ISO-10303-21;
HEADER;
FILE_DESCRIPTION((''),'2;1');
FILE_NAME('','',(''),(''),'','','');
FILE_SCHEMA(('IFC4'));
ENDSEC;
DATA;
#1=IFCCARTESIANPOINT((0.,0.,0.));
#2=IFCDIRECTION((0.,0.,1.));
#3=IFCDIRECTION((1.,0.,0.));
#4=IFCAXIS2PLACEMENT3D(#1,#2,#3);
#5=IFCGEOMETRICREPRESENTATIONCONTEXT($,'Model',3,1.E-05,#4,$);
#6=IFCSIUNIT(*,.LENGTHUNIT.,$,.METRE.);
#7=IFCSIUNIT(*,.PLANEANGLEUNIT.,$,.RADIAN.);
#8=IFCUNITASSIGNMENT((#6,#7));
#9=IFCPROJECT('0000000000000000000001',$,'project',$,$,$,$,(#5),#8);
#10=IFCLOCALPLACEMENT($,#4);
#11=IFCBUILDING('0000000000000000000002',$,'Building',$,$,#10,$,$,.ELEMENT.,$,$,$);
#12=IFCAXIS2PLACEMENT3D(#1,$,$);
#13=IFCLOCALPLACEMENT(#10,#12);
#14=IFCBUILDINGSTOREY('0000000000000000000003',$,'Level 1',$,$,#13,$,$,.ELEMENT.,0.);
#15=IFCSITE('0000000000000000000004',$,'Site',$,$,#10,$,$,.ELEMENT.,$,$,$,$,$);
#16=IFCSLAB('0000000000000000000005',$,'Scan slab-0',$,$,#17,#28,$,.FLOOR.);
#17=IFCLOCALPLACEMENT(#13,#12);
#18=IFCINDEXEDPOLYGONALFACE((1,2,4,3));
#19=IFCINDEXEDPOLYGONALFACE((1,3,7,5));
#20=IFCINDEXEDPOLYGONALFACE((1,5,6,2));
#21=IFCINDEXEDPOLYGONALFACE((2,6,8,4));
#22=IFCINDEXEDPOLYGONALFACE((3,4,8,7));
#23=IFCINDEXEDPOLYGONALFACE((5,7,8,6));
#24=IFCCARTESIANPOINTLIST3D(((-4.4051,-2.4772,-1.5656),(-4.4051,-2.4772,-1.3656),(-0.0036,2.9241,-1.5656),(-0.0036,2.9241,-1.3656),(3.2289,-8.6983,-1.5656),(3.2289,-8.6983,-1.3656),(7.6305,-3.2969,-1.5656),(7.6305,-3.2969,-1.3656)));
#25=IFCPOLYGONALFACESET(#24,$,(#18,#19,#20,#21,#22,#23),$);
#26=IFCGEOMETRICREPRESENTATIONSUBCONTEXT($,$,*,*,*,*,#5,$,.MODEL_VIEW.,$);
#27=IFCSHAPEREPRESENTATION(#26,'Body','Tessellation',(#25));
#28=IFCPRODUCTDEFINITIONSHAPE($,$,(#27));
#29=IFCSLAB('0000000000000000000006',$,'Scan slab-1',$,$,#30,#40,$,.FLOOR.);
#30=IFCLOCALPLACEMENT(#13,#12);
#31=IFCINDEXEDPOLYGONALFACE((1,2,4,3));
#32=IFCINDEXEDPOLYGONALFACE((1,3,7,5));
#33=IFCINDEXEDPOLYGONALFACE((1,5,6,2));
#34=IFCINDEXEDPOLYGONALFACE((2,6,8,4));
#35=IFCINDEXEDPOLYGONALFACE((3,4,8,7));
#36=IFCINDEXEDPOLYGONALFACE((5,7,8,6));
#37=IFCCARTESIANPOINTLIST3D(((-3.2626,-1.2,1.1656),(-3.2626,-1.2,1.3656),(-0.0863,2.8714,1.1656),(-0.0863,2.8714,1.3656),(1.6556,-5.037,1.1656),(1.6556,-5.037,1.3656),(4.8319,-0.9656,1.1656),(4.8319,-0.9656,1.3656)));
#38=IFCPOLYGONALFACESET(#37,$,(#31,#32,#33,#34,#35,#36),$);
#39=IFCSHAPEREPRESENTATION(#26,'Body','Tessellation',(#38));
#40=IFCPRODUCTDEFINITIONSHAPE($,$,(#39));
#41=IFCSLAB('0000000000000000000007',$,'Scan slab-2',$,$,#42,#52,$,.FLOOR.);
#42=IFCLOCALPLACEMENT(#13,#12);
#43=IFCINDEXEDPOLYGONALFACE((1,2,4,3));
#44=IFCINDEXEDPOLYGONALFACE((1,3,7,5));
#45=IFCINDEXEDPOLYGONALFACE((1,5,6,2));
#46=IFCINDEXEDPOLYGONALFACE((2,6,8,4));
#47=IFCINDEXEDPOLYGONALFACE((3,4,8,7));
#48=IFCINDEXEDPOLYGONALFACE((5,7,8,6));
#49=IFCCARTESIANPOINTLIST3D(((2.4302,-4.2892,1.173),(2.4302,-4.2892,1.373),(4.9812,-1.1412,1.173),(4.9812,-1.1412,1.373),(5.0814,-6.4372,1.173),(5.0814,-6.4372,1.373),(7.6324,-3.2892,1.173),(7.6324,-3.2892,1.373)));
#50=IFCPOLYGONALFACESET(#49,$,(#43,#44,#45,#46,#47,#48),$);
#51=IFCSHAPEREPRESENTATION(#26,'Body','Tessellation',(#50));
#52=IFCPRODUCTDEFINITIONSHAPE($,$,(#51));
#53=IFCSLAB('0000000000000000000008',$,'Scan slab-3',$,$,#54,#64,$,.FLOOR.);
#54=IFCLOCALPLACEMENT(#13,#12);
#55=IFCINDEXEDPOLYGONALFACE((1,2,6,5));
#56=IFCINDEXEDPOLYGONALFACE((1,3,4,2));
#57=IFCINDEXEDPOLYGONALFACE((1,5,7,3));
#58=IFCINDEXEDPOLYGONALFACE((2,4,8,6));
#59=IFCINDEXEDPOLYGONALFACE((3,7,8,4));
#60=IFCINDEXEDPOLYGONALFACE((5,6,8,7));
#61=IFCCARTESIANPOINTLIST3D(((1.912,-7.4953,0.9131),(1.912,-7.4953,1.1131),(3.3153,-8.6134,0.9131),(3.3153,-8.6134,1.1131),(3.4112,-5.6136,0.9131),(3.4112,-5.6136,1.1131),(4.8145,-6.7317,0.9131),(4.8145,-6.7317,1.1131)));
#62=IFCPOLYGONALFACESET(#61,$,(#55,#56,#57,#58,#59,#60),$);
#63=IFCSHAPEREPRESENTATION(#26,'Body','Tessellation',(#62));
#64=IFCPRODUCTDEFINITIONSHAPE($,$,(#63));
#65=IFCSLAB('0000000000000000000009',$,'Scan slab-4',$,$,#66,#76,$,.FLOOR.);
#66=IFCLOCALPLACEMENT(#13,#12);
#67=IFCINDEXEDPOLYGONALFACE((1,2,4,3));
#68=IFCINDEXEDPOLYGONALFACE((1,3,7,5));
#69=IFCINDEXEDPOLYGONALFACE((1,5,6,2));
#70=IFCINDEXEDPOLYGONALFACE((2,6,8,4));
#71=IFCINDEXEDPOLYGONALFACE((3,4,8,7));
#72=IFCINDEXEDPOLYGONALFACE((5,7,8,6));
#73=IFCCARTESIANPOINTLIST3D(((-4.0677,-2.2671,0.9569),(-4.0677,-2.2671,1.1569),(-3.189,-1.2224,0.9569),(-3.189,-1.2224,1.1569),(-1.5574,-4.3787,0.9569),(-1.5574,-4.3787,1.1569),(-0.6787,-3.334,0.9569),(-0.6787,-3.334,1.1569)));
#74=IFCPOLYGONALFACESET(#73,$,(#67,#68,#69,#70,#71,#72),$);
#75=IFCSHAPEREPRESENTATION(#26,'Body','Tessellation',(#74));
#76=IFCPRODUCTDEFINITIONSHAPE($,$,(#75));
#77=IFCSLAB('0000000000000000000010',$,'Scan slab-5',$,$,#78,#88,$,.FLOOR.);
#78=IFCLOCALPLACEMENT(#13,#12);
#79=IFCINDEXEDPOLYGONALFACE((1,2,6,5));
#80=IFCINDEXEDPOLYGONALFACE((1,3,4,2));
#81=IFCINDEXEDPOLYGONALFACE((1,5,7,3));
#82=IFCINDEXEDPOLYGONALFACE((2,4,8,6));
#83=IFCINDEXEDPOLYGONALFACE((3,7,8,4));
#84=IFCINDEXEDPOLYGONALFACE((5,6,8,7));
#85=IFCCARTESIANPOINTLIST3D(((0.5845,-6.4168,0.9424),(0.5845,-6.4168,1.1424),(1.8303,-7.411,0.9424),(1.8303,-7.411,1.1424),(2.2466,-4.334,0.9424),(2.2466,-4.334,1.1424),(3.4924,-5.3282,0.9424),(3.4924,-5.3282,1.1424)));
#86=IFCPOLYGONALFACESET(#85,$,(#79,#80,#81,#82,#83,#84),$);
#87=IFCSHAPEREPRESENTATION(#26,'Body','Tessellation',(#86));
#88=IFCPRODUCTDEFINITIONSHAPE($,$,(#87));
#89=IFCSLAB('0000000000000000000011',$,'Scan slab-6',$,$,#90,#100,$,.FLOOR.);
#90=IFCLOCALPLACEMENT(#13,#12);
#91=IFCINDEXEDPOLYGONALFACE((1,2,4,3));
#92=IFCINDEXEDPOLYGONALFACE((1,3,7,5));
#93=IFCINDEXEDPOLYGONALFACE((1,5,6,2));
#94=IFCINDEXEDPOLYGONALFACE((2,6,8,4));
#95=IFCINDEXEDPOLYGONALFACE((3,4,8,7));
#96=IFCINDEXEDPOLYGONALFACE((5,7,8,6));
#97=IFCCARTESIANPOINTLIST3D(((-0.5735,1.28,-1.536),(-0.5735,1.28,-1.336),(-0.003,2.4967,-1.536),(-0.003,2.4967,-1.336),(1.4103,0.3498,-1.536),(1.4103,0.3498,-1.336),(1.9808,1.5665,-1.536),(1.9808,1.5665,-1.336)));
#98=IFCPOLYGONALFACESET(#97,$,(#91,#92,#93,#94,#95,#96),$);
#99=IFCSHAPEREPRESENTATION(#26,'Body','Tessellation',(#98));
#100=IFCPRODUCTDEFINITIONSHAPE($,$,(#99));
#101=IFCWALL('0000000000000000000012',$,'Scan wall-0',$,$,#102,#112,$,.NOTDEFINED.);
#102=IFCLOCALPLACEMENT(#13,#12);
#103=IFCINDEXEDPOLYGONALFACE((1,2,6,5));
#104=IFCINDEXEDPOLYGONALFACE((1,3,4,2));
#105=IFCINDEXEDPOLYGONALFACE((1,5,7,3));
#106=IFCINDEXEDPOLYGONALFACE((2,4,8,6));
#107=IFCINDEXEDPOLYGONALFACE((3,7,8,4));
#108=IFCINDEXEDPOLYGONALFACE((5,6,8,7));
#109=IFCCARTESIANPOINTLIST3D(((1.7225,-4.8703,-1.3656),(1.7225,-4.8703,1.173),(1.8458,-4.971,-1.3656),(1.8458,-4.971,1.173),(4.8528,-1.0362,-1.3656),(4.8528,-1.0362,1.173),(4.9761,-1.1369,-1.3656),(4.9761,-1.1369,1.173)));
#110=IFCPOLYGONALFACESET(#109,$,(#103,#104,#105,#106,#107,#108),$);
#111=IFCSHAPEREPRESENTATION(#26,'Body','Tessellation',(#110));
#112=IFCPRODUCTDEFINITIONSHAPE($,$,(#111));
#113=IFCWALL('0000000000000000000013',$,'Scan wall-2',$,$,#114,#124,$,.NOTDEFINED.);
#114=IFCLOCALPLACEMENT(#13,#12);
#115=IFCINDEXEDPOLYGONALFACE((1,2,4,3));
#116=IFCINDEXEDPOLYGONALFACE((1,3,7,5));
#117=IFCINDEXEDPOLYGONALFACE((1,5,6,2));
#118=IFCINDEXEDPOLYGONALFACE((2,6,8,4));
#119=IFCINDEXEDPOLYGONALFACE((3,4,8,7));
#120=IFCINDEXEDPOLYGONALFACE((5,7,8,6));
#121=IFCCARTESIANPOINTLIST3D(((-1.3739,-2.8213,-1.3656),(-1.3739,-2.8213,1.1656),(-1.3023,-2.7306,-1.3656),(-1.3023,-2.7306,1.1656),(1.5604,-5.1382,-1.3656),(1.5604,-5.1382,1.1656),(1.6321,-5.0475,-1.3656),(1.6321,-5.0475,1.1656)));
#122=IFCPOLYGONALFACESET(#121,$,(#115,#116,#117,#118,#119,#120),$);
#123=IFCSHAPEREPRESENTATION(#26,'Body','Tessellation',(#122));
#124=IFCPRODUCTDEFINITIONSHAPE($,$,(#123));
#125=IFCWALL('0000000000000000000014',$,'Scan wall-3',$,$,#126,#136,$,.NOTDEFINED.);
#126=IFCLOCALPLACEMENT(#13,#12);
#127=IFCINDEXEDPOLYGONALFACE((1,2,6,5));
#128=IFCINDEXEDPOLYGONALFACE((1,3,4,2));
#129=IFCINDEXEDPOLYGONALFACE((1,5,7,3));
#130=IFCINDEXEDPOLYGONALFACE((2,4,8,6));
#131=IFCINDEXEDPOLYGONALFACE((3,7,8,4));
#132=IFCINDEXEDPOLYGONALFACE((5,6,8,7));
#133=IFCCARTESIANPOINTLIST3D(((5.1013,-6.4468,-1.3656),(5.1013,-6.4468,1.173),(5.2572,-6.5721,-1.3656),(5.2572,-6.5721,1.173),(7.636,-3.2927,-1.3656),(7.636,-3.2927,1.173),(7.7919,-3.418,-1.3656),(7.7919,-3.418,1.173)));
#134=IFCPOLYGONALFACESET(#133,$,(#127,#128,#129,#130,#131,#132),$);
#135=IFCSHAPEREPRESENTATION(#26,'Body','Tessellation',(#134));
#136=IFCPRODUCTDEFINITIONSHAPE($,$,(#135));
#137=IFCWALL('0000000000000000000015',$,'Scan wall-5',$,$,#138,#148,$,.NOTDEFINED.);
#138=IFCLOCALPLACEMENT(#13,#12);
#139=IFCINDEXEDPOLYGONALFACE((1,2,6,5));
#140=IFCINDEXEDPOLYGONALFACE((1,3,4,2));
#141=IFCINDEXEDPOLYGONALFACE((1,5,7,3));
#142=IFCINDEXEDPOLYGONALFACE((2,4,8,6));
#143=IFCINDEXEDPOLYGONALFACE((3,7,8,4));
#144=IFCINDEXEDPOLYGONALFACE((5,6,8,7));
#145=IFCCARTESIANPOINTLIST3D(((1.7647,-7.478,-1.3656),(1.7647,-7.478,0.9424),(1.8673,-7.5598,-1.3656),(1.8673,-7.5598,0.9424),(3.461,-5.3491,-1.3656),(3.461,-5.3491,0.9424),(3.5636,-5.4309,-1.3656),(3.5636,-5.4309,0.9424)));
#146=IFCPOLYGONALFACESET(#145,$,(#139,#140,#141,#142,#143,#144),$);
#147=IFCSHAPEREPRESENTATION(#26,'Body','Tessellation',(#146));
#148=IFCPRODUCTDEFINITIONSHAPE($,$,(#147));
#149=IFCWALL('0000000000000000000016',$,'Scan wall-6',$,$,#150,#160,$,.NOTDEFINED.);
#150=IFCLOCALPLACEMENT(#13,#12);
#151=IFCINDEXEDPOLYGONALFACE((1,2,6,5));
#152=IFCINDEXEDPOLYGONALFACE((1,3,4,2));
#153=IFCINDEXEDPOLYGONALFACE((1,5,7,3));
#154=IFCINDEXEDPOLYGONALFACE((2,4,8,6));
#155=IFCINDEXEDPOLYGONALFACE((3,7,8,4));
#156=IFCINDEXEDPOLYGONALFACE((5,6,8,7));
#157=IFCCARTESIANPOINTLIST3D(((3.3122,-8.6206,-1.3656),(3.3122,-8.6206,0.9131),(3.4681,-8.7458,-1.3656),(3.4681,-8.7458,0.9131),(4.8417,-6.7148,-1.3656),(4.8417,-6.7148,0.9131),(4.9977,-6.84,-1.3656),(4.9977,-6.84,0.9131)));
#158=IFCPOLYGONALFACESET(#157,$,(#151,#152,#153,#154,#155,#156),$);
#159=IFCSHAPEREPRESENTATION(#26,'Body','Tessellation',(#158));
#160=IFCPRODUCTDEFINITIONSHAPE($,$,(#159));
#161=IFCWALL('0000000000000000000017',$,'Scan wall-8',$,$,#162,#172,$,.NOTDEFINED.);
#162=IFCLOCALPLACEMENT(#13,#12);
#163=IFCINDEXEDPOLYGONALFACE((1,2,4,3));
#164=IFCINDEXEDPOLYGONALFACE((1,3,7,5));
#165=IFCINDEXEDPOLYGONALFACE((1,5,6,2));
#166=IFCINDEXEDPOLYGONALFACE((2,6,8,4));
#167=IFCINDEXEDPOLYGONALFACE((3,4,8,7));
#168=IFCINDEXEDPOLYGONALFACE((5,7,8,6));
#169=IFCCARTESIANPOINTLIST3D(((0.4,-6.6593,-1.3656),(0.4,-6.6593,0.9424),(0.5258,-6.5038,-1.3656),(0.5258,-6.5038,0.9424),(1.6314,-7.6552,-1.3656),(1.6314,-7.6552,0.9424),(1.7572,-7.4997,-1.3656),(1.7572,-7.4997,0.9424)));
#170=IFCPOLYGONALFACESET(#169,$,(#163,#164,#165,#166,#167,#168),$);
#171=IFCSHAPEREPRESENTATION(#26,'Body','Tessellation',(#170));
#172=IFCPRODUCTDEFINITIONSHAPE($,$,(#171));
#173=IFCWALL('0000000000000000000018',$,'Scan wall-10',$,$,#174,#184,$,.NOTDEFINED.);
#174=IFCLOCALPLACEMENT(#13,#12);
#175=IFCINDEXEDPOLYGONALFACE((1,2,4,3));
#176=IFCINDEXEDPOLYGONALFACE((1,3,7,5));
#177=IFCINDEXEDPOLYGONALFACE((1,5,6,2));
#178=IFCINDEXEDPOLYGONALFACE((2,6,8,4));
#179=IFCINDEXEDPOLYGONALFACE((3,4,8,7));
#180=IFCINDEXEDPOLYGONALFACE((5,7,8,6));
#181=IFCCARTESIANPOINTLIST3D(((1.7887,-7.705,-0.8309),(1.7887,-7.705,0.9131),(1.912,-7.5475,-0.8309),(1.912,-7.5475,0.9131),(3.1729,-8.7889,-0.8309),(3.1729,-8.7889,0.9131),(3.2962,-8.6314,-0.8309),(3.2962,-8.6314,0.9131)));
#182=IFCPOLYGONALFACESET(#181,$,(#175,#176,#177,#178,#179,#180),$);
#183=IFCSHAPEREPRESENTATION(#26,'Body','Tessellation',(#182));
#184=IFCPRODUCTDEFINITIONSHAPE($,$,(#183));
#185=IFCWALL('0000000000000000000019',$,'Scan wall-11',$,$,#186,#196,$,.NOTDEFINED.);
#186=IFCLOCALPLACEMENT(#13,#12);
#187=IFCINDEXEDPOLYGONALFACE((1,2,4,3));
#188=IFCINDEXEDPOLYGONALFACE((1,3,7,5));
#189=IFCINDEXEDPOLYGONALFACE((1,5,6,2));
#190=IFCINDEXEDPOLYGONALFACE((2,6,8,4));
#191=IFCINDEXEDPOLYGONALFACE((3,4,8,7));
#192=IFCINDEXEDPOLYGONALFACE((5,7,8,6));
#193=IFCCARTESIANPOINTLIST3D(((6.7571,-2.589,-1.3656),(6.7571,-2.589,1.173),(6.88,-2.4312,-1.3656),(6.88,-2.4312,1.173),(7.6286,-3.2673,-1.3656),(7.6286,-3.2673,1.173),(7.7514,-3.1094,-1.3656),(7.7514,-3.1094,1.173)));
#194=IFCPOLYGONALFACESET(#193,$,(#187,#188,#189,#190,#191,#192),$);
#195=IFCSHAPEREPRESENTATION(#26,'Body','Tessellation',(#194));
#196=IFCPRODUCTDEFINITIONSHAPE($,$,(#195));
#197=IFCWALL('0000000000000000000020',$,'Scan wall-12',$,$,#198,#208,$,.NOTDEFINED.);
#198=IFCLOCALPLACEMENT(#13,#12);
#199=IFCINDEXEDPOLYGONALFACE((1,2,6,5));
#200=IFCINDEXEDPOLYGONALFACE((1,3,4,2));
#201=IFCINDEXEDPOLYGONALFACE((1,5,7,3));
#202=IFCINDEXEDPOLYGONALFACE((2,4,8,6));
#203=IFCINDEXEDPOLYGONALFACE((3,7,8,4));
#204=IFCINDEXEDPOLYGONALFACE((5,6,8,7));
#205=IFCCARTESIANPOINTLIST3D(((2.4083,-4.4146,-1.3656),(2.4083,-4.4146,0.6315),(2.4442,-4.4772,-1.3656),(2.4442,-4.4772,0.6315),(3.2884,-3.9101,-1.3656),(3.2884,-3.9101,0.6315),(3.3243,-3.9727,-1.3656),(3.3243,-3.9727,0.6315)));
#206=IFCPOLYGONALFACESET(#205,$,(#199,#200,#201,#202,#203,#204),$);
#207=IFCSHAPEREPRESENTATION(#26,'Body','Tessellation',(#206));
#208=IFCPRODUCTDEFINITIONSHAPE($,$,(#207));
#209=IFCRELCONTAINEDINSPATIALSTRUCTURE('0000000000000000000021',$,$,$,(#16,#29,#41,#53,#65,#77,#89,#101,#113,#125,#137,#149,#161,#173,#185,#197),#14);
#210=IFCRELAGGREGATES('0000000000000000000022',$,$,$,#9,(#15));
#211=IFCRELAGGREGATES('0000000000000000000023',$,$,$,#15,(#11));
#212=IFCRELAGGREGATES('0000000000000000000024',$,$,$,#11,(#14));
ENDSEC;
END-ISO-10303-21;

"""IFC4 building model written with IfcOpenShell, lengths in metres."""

from ifc_helpers import new_model, si_unit, frame, frame_2d, origin, origin_with_axes, place, context, subcontext, project, spatial, polyline, rectangle, outline, extrude, element, save


model = new_model("IFC4")

# Units and contexts
model_context = context("Model", 3, precision=1e-05, world=origin_with_axes())
sub_context = subcontext(model_context, None, None, "MODEL_VIEW")
ifc_project = project(units=[si_unit("LENGTHUNIT", "METRE"), si_unit("PLANEANGLEUNIT", "RADIAN")], contexts=[model_context])

# Site, building, storey
placement = place(None, origin_with_axes())
site = spatial("IfcSite", under=ifc_project, at=placement, Name="Site", CompositionType="ELEMENT")
building = spatial("IfcBuilding", under=site, at=placement, Name="Building", CompositionType="ELEMENT")
storey_placement = place(placement, origin())
storey = spatial("IfcBuildingStorey", under=building, at=storey_placement, Name="Level 1", CompositionType="ELEMENT", Elevation=0.0)

# Slabs
slab_1_placement = place(storey_placement, frame((0.0, 0.0, -1.5656)))
element("IfcSlab", 1, at=slab_1_placement, inside=storey, Name="Scan slab-0", PredefinedType="FLOOR", context=sub_context, shape_type="SweptSolid", body=[
    extrude(outline(polyline([(-4.4051, -2.4772), (3.2289, -8.6983), (7.6305, -3.2969), (-0.0036, 2.9241), (-4.4051, -2.4772)])), origin(), (0.0, 0.0, 1.0), 0.2),
])
slab_2_placement = place(storey_placement, frame((0.0, 0.0, 1.1656)))
element("IfcSlab", 2, at=slab_2_placement, inside=storey, Name="Scan slab-1", PredefinedType="FLOOR", context=sub_context, shape_type="SweptSolid", body=[
    extrude(outline(polyline([(-3.2626, -1.2), (1.6556, -5.037), (4.8319, -0.9656), (-0.0863, 2.8714), (-3.2626, -1.2)])), origin(), (0.0, 0.0, 1.0), 0.2),
])
slab_3_placement = place(storey_placement, frame((0.0, 0.0, 1.173)))
element("IfcSlab", 3, at=slab_3_placement, inside=storey, Name="Scan slab-2", PredefinedType="FLOOR", context=sub_context, shape_type="SweptSolid", body=[
    extrude(outline(polyline([(4.9812, -1.1412), (2.4302, -4.2892), (5.0814, -6.4372), (7.6324, -3.2892), (4.9812, -1.1412)])), origin(), (0.0, 0.0, 1.0), 0.2),
])
slab_4_placement = place(storey_placement, frame((0.0, 0.0, 0.9131)))
element("IfcSlab", 4, at=slab_4_placement, inside=storey, Name="Scan slab-3", PredefinedType="FLOOR", context=sub_context, shape_type="SweptSolid", body=[
    extrude(outline(polyline([(1.912, -7.4953), (3.3153, -8.6134), (4.8145, -6.7317), (3.4112, -5.6136), (1.912, -7.4953)])), origin(), (0.0, 0.0, 1.0), 0.2),
])
slab_5_placement = place(storey_placement, frame((0.0, 0.0, 0.9569)))
element("IfcSlab", 5, at=slab_5_placement, inside=storey, Name="Scan slab-4", PredefinedType="FLOOR", context=sub_context, shape_type="SweptSolid", body=[
    extrude(outline(polyline([(-4.0677, -2.2671), (-1.5574, -4.3787), (-0.6787, -3.334), (-3.189, -1.2224), (-4.0677, -2.2671)])), origin(), (0.0, 0.0, 1.0), 0.2),
])
slab_6_placement = place(storey_placement, frame((0.0, 0.0, 0.9424)))
element("IfcSlab", 6, at=slab_6_placement, inside=storey, Name="Scan slab-5", PredefinedType="FLOOR", context=sub_context, shape_type="SweptSolid", body=[
    extrude(outline(polyline([(2.2466, -4.334), (0.5845, -6.4168), (1.8303, -7.411), (3.4924, -5.3282), (2.2466, -4.334)])), origin(), (0.0, 0.0, 1.0), 0.2),
])
slab_7_placement = place(storey_placement, frame((0.0, 0.0, -1.536)))
element("IfcSlab", 7, at=slab_7_placement, inside=storey, Name="Scan slab-6", PredefinedType="FLOOR", context=sub_context, shape_type="SweptSolid", body=[
    extrude(outline(polyline([(-0.5735, 1.28), (1.4103, 0.3498), (1.9808, 1.5665), (-0.003, 2.4967), (-0.5735, 1.28)])), origin(), (0.0, 0.0, 1.0), 0.2),
])

# Walls
wall_1_placement = place(storey_placement, frame((1.7841, -4.9207, -1.3656), z_axis=(0.0, 0.0, 1.0), x_axis=(0.632426, 0.774621, 0.0)))
element("IfcWall", 8, at=wall_1_placement, inside=storey, Name="Scan wall-0", PredefinedType="NOTDEFINED", context=sub_context, shape_type="SweptSolid", body=[
    extrude(rectangle(XDim=4.9496, YDim=0.1592, at=frame_2d((2.4748, 0.0))), origin(), (0.0, 0.0, 1.0), 2.5386),
])
wall_2_placement = place(storey_placement, frame((1.5962, -5.0929, -1.3656), z_axis=(0.0, 0.0, 1.0), x_axis=(-0.784842, 0.619696, 0.0)))
element("IfcWall", 9, at=wall_2_placement, inside=storey, Name="Scan wall-2", PredefinedType="NOTDEFINED", context=sub_context, shape_type="SweptSolid", body=[
    extrude(rectangle(XDim=3.7388, YDim=0.1156, at=frame_2d((1.8694, 0.0))), origin(), (0.0, 0.0, 1.0), 2.5311),
])
wall_3_placement = place(storey_placement, frame((5.1792, -6.5095, -1.3656), z_axis=(0.0, 0.0, 1.0), x_axis=(0.626416, 0.779489, 0.0)))
element("IfcWall", 10, at=wall_3_placement, inside=storey, Name="Scan wall-3", PredefinedType="NOTDEFINED", context=sub_context, shape_type="SweptSolid", body=[
    extrude(rectangle(XDim=4.0464, YDim=0.2, at=frame_2d((2.0232, 0.0))), origin(), (0.0, 0.0, 1.0), 2.5386),
])
wall_4_placement = place(storey_placement, frame((1.816, -7.5189, -1.3656), z_axis=(0.0, 0.0, 1.0), x_axis=(0.623176, 0.782082, 0.0)))
element("IfcWall", 11, at=wall_4_placement, inside=storey, Name="Scan wall-5", PredefinedType="NOTDEFINED", context=sub_context, shape_type="SweptSolid", body=[
    extrude(rectangle(XDim=2.7221, YDim=0.1312, at=frame_2d((1.361, 0.0))), origin(), (0.0, 0.0, 1.0), 2.3079),
])
wall_5_placement = place(storey_placement, frame((3.3901, -8.6832, -1.3656), z_axis=(0.0, 0.0, 1.0), x_axis=(0.625935, 0.779875, 0.0)))
element("IfcWall", 12, at=wall_5_placement, inside=storey, Name="Scan wall-6", PredefinedType="NOTDEFINED", context=sub_context, shape_type="SweptSolid", body=[
    extrude(rectangle(XDim=2.4437, YDim=0.2, at=frame_2d((1.2218, 0.0))), origin(), (0.0, 0.0, 1.0), 2.2786),
])
wall_6_placement = place(storey_placement, frame((1.6943, -7.5775, -1.3656), z_axis=(0.0, 0.0, 1.0), x_axis=(-0.77751, 0.62887, 0.0)))
element("IfcWall", 13, at=wall_6_placement, inside=storey, Name="Scan wall-8", PredefinedType="NOTDEFINED", context=sub_context, shape_type="SweptSolid", body=[
    extrude(rectangle(XDim=1.5838, YDim=0.2, at=frame_2d((0.7919, 0.0))), origin(), (0.0, 0.0, 1.0), 2.3079),
])
wall_7_placement = place(storey_placement, frame((3.2345, -8.7101, -0.8309), z_axis=(0.0, 0.0, 1.0), x_axis=(-0.787339, 0.616521, 0.0)))
element("IfcWall", 14, at=wall_7_placement, inside=storey, Name="Scan wall-10", PredefinedType="NOTDEFINED", context=sub_context, shape_type="SweptSolid", body=[
    extrude(rectangle(XDim=1.7581, YDim=0.2, at=frame_2d((0.879, 0.0))), origin(), (0.0, 0.0, 1.0), 1.7439),
])
wall_8_placement = place(storey_placement, frame((7.69, -3.1884, -1.3656), z_axis=(0.0, 0.0, 1.0), x_axis=(-0.789159, 0.614189, 0.0)))
element("IfcWall", 15, at=wall_8_placement, inside=storey, Name="Scan wall-11", PredefinedType="NOTDEFINED", context=sub_context, shape_type="SweptSolid", body=[
    extrude(rectangle(XDim=1.1042, YDim=0.2, at=frame_2d((0.5521, 0.0))), origin(), (0.0, 0.0, 1.0), 2.5386),
])
wall_9_placement = place(storey_placement, frame((3.3064, -3.9414, -1.3656), z_axis=(0.0, 0.0, 1.0), x_axis=(-0.867569, -0.497316, 0.0)))
element("IfcWall", 16, at=wall_9_placement, inside=storey, Name="Scan wall-12", PredefinedType="NOTDEFINED", context=sub_context, shape_type="SweptSolid", body=[
    extrude(rectangle(XDim=1.0145, YDim=0.0722, at=frame_2d((0.5072, 0.0))), origin(), (0.0, 0.0, 1.0), 1.9971),
])

save(model, "model.ifc")
